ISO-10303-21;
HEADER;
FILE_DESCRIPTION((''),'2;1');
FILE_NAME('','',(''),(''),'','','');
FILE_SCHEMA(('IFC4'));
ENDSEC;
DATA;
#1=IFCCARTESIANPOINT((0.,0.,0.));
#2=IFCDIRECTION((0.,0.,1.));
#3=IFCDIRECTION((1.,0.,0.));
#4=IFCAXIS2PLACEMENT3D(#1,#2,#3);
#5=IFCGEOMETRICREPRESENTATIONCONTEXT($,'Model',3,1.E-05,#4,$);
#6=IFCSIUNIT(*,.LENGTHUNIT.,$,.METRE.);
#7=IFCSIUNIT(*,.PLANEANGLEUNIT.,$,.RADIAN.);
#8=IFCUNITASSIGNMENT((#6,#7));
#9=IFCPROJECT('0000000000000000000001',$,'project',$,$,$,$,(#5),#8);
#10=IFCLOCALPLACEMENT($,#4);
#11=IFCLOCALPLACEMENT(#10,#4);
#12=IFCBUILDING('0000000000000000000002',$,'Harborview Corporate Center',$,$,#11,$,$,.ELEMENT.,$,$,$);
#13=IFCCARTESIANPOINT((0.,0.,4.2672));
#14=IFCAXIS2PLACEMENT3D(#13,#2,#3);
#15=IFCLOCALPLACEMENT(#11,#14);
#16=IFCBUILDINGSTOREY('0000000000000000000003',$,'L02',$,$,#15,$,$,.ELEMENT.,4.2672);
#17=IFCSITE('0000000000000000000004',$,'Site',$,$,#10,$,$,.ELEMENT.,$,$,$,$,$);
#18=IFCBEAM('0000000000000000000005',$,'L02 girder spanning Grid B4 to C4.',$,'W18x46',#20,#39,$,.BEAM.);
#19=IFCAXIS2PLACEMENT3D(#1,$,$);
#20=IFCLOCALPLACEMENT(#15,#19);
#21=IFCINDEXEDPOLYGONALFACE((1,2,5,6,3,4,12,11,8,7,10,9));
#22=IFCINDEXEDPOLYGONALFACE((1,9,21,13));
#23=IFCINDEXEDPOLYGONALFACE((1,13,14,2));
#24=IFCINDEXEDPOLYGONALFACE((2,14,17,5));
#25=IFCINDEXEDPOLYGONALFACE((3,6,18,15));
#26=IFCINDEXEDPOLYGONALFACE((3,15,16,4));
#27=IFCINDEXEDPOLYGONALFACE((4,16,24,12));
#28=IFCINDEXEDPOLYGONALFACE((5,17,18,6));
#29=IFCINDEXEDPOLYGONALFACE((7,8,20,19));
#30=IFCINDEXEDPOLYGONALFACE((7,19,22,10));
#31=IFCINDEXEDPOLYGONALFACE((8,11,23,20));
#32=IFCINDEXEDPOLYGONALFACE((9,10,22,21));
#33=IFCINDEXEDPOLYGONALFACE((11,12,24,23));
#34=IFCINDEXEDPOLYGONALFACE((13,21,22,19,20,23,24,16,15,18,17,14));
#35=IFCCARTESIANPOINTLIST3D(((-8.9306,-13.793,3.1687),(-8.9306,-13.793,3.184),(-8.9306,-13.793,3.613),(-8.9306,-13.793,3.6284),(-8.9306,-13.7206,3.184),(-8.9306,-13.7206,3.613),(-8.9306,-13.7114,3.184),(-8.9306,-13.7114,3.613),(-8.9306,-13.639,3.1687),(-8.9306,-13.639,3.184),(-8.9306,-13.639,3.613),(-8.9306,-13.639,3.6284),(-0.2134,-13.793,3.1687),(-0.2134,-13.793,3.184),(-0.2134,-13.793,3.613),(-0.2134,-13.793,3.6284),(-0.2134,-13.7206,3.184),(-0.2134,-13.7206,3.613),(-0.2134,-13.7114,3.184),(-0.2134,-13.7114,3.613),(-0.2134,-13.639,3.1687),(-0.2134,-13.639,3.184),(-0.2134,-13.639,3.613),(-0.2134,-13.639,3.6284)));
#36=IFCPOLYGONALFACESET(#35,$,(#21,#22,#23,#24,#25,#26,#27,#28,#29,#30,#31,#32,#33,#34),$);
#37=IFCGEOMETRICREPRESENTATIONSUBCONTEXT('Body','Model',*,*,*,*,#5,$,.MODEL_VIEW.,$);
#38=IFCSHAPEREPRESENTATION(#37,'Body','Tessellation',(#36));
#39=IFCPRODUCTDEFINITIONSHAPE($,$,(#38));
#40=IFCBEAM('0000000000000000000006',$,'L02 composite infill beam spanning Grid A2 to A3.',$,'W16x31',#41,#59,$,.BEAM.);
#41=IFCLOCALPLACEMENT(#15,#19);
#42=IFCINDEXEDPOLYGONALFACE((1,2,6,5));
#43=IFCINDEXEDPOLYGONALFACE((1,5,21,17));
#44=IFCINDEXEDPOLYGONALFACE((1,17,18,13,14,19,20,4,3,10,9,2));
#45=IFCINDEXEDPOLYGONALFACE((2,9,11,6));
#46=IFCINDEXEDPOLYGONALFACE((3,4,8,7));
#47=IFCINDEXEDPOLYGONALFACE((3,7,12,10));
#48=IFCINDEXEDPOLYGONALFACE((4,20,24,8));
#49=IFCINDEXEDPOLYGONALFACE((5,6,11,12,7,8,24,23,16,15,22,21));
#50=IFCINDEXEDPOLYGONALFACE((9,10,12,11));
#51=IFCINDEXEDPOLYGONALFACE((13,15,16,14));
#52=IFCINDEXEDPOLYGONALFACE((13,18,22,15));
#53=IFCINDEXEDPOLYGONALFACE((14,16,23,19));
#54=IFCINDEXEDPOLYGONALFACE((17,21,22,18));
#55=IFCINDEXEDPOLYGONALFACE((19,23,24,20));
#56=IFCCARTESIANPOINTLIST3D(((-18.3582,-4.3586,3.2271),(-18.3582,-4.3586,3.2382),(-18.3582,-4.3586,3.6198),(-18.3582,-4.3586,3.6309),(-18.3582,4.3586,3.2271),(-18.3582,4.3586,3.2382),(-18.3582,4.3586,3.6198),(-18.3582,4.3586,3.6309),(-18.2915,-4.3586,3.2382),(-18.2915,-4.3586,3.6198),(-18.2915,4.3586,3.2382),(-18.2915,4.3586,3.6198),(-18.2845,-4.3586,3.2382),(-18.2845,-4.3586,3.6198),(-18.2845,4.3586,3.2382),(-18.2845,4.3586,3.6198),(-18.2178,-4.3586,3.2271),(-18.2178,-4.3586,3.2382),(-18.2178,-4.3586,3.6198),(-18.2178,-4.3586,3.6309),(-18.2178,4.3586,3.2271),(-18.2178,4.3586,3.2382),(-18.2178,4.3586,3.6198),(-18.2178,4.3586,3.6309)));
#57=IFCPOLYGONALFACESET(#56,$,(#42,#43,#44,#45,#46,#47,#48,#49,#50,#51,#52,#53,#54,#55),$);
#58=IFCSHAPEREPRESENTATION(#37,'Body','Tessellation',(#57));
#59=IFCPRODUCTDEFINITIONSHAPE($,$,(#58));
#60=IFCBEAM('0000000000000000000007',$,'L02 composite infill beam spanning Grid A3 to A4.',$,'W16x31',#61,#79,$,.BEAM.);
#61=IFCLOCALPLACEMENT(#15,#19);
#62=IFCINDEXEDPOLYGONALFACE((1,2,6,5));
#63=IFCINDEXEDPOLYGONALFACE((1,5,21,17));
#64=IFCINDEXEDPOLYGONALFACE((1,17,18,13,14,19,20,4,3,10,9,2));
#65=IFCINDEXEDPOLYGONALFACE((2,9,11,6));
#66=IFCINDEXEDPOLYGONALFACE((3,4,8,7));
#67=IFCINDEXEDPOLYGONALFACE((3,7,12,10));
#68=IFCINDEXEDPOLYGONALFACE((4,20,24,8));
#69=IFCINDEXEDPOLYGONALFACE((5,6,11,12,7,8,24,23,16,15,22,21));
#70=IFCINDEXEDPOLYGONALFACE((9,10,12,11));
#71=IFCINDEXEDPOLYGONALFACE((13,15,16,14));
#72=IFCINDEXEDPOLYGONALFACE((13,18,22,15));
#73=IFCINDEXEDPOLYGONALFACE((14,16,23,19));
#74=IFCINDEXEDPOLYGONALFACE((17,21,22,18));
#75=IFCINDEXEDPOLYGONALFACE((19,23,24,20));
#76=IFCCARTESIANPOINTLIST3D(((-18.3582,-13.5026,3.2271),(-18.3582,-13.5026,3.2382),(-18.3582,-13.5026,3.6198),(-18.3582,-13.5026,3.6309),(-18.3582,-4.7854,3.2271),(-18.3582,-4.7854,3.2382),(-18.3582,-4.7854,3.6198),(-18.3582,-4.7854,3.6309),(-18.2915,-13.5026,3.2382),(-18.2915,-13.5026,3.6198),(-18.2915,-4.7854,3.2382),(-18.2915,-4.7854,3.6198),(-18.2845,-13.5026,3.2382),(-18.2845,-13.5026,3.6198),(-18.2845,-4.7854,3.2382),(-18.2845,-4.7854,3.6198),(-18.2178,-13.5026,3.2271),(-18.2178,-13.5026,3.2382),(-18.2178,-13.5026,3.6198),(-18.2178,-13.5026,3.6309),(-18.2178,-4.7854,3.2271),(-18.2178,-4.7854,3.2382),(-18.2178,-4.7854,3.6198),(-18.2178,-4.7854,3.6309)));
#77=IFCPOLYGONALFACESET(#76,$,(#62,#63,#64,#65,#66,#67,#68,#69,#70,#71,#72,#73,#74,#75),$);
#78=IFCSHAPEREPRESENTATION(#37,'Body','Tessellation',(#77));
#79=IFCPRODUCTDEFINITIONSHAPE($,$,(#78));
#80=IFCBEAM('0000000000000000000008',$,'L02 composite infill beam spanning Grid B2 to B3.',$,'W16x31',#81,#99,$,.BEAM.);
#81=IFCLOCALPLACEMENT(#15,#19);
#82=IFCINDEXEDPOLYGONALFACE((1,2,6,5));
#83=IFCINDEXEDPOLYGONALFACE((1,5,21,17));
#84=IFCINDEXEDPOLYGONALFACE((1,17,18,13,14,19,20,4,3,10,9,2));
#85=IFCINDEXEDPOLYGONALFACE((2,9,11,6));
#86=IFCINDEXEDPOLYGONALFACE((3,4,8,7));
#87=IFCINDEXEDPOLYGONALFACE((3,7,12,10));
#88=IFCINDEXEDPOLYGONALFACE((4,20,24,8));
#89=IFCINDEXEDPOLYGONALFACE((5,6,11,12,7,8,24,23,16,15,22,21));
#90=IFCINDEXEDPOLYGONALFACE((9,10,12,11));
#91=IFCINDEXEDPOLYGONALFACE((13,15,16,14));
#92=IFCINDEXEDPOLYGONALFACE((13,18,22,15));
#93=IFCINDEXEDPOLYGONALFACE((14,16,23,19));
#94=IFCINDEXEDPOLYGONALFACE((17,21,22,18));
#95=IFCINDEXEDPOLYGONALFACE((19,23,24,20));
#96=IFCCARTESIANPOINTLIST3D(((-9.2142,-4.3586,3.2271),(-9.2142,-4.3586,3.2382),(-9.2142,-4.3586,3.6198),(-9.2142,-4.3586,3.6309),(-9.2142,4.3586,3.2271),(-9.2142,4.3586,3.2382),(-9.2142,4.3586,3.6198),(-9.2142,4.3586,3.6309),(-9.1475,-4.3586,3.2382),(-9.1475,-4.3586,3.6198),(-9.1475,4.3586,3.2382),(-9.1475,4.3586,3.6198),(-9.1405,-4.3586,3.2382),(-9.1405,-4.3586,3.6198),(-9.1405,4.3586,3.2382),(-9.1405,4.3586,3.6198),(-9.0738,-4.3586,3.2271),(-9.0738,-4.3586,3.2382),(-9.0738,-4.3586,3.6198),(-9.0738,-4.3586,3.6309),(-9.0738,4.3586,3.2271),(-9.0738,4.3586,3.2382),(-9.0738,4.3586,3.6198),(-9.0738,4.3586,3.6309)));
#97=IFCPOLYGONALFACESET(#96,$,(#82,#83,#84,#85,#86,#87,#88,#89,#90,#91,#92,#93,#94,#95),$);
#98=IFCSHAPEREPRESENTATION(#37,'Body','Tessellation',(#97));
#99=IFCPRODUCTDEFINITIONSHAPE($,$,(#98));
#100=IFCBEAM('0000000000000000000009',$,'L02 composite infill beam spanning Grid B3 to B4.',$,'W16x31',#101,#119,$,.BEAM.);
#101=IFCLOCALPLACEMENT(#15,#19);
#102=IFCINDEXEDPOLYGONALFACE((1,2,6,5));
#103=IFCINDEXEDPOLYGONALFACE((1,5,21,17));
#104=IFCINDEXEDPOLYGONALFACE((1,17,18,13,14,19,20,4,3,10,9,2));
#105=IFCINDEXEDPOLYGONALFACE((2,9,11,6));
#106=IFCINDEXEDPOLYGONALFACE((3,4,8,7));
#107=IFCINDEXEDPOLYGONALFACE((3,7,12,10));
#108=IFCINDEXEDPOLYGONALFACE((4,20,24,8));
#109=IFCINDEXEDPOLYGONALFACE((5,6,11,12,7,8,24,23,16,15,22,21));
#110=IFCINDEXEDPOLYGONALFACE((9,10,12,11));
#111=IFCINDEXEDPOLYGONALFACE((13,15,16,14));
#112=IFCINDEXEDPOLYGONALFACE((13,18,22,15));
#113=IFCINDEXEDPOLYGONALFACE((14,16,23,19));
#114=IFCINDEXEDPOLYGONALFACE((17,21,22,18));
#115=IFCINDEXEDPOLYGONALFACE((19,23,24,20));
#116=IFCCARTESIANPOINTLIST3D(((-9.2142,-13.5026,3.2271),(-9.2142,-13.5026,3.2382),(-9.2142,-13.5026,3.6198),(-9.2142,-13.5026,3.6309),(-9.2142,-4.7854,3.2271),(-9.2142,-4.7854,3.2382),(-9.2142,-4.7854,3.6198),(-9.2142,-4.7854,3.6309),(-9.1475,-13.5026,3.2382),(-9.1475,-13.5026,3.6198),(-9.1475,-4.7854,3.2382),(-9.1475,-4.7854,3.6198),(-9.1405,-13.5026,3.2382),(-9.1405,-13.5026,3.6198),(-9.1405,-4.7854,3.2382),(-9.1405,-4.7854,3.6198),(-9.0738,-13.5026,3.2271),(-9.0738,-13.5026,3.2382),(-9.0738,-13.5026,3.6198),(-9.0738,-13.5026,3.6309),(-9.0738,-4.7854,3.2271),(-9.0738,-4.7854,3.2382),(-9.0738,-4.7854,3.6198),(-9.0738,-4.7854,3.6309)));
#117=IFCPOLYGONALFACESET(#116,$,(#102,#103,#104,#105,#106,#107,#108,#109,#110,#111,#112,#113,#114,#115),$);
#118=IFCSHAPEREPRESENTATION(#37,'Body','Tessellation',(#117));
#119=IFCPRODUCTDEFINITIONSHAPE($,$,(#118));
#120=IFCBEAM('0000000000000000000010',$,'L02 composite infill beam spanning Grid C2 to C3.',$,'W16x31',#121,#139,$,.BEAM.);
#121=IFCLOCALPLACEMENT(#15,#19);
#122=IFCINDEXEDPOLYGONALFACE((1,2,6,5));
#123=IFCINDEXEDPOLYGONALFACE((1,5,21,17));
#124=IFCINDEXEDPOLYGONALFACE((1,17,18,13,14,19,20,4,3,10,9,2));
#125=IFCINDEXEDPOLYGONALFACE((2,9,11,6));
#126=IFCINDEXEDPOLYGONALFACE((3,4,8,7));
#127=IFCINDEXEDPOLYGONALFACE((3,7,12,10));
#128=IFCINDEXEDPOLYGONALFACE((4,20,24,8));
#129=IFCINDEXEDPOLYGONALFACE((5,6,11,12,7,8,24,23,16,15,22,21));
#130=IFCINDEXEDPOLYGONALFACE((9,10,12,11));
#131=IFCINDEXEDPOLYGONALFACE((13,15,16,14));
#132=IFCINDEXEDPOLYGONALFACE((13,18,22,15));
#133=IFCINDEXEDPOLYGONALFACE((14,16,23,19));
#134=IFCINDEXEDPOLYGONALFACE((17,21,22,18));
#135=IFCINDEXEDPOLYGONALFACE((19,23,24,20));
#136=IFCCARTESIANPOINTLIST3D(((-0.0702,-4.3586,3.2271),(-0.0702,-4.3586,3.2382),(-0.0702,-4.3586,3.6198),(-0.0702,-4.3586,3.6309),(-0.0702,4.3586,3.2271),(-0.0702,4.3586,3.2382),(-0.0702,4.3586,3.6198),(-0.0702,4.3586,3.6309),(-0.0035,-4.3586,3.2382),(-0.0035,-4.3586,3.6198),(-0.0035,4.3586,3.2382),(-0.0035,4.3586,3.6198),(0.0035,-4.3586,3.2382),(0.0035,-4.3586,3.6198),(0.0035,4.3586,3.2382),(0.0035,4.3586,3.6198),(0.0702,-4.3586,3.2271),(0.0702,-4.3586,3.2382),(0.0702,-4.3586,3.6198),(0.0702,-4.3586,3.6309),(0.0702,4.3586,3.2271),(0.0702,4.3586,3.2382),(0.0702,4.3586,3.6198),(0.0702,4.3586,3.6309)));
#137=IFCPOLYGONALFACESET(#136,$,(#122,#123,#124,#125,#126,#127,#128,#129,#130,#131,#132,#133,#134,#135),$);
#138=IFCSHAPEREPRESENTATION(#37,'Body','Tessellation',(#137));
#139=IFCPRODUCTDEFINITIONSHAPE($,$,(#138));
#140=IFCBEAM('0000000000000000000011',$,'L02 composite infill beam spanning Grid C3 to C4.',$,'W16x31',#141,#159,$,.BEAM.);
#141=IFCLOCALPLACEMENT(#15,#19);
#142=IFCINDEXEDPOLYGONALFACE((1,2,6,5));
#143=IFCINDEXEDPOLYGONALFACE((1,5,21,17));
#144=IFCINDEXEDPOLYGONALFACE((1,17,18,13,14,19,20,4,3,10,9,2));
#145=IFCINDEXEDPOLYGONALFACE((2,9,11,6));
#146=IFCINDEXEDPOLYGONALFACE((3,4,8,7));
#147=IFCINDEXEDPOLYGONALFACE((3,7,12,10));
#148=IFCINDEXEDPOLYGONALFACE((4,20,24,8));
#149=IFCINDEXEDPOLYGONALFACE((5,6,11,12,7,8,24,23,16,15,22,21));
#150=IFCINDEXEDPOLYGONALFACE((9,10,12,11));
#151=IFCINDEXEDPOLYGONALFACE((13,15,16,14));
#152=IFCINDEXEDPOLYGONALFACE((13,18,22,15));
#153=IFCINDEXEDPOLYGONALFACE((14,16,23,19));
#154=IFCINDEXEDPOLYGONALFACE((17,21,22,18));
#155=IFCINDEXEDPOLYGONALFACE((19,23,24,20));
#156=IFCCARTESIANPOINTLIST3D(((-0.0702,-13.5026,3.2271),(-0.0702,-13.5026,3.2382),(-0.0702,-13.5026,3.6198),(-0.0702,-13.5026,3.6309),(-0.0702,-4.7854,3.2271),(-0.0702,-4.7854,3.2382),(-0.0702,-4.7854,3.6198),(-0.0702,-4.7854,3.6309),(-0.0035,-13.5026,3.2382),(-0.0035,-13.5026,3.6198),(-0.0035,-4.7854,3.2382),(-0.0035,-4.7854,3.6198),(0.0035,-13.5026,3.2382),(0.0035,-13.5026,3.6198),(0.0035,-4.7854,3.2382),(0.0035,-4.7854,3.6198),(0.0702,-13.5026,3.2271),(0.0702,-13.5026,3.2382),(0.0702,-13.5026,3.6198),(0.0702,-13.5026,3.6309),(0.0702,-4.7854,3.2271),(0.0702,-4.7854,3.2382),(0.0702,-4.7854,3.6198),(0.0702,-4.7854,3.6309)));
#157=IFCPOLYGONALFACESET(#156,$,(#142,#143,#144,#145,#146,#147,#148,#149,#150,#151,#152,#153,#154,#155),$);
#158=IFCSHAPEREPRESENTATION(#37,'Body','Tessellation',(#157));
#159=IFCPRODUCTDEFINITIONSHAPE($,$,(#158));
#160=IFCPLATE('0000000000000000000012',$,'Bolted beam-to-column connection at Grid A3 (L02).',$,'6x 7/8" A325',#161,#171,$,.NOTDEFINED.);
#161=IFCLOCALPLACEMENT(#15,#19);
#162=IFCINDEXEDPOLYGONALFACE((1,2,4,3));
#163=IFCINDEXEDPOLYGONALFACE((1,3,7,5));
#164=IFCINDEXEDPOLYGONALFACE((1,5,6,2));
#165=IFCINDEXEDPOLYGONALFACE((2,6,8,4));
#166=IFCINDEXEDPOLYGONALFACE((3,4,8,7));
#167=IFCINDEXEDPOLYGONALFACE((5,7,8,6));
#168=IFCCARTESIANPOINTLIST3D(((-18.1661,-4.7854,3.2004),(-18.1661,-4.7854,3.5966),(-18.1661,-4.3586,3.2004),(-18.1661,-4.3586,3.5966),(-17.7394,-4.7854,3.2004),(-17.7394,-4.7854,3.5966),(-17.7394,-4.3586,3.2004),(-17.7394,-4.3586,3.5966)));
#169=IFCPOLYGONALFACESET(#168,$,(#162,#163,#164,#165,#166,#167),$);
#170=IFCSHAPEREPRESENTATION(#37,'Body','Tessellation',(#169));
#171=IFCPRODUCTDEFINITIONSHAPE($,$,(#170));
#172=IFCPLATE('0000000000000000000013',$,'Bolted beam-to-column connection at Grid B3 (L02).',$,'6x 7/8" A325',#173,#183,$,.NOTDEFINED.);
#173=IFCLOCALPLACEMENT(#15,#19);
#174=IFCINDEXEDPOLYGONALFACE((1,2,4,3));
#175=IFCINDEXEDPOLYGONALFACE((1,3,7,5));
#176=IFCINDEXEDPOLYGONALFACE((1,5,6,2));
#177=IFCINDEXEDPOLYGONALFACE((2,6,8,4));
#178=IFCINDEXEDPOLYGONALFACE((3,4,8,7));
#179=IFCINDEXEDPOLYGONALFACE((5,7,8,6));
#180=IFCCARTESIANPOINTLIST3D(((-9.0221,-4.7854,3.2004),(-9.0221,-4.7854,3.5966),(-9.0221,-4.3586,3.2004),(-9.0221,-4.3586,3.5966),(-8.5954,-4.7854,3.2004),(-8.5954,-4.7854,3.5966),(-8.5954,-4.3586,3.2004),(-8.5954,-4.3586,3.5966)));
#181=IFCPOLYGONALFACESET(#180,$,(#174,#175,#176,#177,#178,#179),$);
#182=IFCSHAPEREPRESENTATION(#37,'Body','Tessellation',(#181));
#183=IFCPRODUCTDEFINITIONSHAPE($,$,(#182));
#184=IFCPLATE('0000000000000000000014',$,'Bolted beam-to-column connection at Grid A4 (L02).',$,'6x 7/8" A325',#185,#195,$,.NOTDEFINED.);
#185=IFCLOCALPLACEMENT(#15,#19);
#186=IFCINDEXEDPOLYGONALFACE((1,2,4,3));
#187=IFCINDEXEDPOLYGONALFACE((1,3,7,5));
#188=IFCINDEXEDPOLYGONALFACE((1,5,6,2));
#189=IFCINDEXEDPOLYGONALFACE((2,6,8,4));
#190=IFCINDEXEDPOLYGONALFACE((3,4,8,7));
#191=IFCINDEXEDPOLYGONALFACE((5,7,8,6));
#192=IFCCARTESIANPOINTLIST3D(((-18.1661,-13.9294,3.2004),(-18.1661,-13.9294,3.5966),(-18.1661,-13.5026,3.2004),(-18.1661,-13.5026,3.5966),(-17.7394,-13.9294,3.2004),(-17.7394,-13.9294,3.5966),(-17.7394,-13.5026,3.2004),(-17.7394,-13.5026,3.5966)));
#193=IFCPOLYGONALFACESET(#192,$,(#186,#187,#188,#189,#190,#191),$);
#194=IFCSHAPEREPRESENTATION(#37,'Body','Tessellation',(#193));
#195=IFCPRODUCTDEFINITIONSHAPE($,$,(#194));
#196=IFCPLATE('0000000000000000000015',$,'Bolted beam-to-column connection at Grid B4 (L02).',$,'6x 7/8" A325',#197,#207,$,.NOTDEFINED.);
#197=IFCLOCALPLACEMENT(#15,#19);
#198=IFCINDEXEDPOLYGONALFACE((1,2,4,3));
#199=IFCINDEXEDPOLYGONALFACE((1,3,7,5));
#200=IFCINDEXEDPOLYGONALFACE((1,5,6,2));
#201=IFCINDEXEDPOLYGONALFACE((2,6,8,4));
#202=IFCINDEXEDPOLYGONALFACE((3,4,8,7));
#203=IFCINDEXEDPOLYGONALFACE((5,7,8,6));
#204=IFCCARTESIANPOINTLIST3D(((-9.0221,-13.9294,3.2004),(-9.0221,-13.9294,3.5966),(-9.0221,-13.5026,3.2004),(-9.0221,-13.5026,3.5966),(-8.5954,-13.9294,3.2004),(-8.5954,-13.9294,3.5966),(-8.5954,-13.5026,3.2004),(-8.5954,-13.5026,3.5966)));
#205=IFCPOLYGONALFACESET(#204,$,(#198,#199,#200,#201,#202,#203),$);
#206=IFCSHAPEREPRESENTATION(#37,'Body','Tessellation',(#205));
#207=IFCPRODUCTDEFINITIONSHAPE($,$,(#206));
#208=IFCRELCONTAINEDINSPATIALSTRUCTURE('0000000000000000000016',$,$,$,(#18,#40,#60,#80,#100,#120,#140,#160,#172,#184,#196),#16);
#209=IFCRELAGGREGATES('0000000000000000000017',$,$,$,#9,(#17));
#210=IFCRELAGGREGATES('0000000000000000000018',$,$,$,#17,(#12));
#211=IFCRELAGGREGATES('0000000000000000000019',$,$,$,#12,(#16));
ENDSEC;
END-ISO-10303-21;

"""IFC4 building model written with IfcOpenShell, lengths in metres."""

from ifc_helpers import new_model, si_unit, frame, origin_with_axes, place, context, subcontext, project, spatial, rectangle, i_section, extrude, element, save


model = new_model("IFC4")

# Units and contexts
model_context = context("Model", 3, precision=1e-05, world=origin_with_axes())
body_context = subcontext(model_context, "Body", "Model", "MODEL_VIEW")
ifc_project = project(units=[si_unit("LENGTHUNIT", "METRE"), si_unit("PLANEANGLEUNIT", "RADIAN")], contexts=[model_context])

# Site, building, storey
site_placement = place(None, origin_with_axes())
site = spatial("IfcSite", under=ifc_project, at=site_placement, Name="Site", CompositionType="ELEMENT")
building_placement = place(site_placement, origin_with_axes())
building = spatial("IfcBuilding", under=site, at=building_placement, Name="Harborview Corporate Center", CompositionType="ELEMENT")
storey_placement = place(building_placement, frame((0.0, 0.0, 4.2672), z_axis=(0.0, 0.0, 1.0), x_axis=(1.0, 0.0, 0.0)))
storey = spatial("IfcBuildingStorey", under=building, at=storey_placement, Name="L02", CompositionType="ELEMENT", Elevation=4.2672)

# Beams
beam_1_placement = place(storey_placement, frame((-8.9306, -13.716, 3.3985), z_axis=(1.0, 0.0, 0.0), x_axis=(0.0, 1.0, 0.0)))
element("IfcBeam", 1, at=beam_1_placement, inside=storey, Name="L02 girder spanning Grid B4 to C4.", ObjectType="W18x46", PredefinedType="BEAM", context=body_context, shape_type="SweptSolid", body=[
    extrude(i_section(OverallWidth=0.1539, OverallDepth=0.4597, WebThickness=0.0091, FlangeThickness=0.0154), origin_with_axes(), (0.0, 0.0, 1.0), 8.7173),
])
beam_2_placement = place(storey_placement, frame((-18.288, -4.3586, 3.429), z_axis=(0.0, 1.0, 0.0), x_axis=(-1.0, 0.0, 0.0)))
element("IfcBeam", 2, at=beam_2_placement, inside=storey, Name="L02 composite infill beam spanning Grid A2 to A3.", ObjectType="W16x31", PredefinedType="BEAM", context=body_context, shape_type="SweptSolid", body=[
    extrude(i_section(OverallWidth=0.1405, OverallDepth=0.4039, WebThickness=0.007, FlangeThickness=0.0112), origin_with_axes(), (0.0, 0.0, 1.0), 8.7173),
])
beam_3_placement = place(storey_placement, frame((-18.288, -13.5026, 3.429), z_axis=(0.0, 1.0, 0.0), x_axis=(-1.0, 0.0, 0.0)))
element("IfcBeam", 3, at=beam_3_placement, inside=storey, Name="L02 composite infill beam spanning Grid A3 to A4.", ObjectType="W16x31", PredefinedType="BEAM", context=body_context, shape_type="SweptSolid", body=[
    extrude(i_section(OverallWidth=0.1405, OverallDepth=0.4039, WebThickness=0.007, FlangeThickness=0.0112), origin_with_axes(), (0.0, 0.0, 1.0), 8.7173),
])
beam_4_placement = place(storey_placement, frame((-9.144, -4.3586, 3.429), z_axis=(0.0, 1.0, 0.0), x_axis=(-1.0, 0.0, 0.0)))
element("IfcBeam", 4, at=beam_4_placement, inside=storey, Name="L02 composite infill beam spanning Grid B2 to B3.", ObjectType="W16x31", PredefinedType="BEAM", context=body_context, shape_type="SweptSolid", body=[
    extrude(i_section(OverallWidth=0.1405, OverallDepth=0.4039, WebThickness=0.007, FlangeThickness=0.0112), origin_with_axes(), (0.0, 0.0, 1.0), 8.7173),
])
beam_5_placement = place(storey_placement, frame((-9.144, -13.5026, 3.429), z_axis=(0.0, 1.0, 0.0), x_axis=(-1.0, 0.0, 0.0)))
element("IfcBeam", 5, at=beam_5_placement, inside=storey, Name="L02 composite infill beam spanning Grid B3 to B4.", ObjectType="W16x31", PredefinedType="BEAM", context=body_context, shape_type="SweptSolid", body=[
    extrude(i_section(OverallWidth=0.1405, OverallDepth=0.4039, WebThickness=0.007, FlangeThickness=0.0112), origin_with_axes(), (0.0, 0.0, 1.0), 8.7173),
])
beam_6_placement = place(storey_placement, frame((0.0, -4.3586, 3.429), z_axis=(0.0, 1.0, 0.0), x_axis=(-1.0, 0.0, 0.0)))
element("IfcBeam", 6, at=beam_6_placement, inside=storey, Name="L02 composite infill beam spanning Grid C2 to C3.", ObjectType="W16x31", PredefinedType="BEAM", context=body_context, shape_type="SweptSolid", body=[
    extrude(i_section(OverallWidth=0.1405, OverallDepth=0.4039, WebThickness=0.007, FlangeThickness=0.0112), origin_with_axes(), (0.0, 0.0, 1.0), 8.7173),
])
beam_7_placement = place(storey_placement, frame((0.0, -13.5026, 3.429), z_axis=(0.0, 1.0, 0.0), x_axis=(-1.0, 0.0, 0.0)))
element("IfcBeam", 7, at=beam_7_placement, inside=storey, Name="L02 composite infill beam spanning Grid C3 to C4.", ObjectType="W16x31", PredefinedType="BEAM", context=body_context, shape_type="SweptSolid", body=[
    extrude(i_section(OverallWidth=0.1405, OverallDepth=0.4039, WebThickness=0.007, FlangeThickness=0.0112), origin_with_axes(), (0.0, 0.0, 1.0), 8.7173),
])

# Plates
plate_1_placement = place(storey_placement, frame((-17.9527, -4.572, 3.2004), z_axis=(0.0, 0.0, 1.0), x_axis=(1.0, 0.0, 0.0)))
element("IfcPlate", 8, at=plate_1_placement, inside=storey, Name="Bolted beam-to-column connection at Grid A3 (L02).", ObjectType="6x 7/8\" A325", PredefinedType="NOTDEFINED", context=body_context, shape_type="SweptSolid", body=[
    extrude(rectangle(XDim=0.4267, YDim=0.4267), origin_with_axes(), (0.0, 0.0, 1.0), 0.3962),
])
plate_2_placement = place(storey_placement, frame((-8.8087, -4.572, 3.2004), z_axis=(0.0, 0.0, 1.0), x_axis=(1.0, 0.0, 0.0)))
element("IfcPlate", 9, at=plate_2_placement, inside=storey, Name="Bolted beam-to-column connection at Grid B3 (L02).", ObjectType="6x 7/8\" A325", PredefinedType="NOTDEFINED", context=body_context, shape_type="SweptSolid", body=[
    extrude(rectangle(XDim=0.4267, YDim=0.4267), origin_with_axes(), (0.0, 0.0, 1.0), 0.3962),
])
plate_3_placement = place(storey_placement, frame((-17.9527, -13.716, 3.2004), z_axis=(0.0, 0.0, 1.0), x_axis=(1.0, 0.0, 0.0)))
element("IfcPlate", 10, at=plate_3_placement, inside=storey, Name="Bolted beam-to-column connection at Grid A4 (L02).", ObjectType="6x 7/8\" A325", PredefinedType="NOTDEFINED", context=body_context, shape_type="SweptSolid", body=[
    extrude(rectangle(XDim=0.4267, YDim=0.4267), origin_with_axes(), (0.0, 0.0, 1.0), 0.3962),
])
plate_4_placement = place(storey_placement, frame((-8.8087, -13.716, 3.2004), z_axis=(0.0, 0.0, 1.0), x_axis=(1.0, 0.0, 0.0)))
element("IfcPlate", 11, at=plate_4_placement, inside=storey, Name="Bolted beam-to-column connection at Grid B4 (L02).", ObjectType="6x 7/8\" A325", PredefinedType="NOTDEFINED", context=body_context, shape_type="SweptSolid", body=[
    extrude(rectangle(XDim=0.4267, YDim=0.4267), origin_with_axes(), (0.0, 0.0, 1.0), 0.3962),
])

save(model, "model.ifc")
